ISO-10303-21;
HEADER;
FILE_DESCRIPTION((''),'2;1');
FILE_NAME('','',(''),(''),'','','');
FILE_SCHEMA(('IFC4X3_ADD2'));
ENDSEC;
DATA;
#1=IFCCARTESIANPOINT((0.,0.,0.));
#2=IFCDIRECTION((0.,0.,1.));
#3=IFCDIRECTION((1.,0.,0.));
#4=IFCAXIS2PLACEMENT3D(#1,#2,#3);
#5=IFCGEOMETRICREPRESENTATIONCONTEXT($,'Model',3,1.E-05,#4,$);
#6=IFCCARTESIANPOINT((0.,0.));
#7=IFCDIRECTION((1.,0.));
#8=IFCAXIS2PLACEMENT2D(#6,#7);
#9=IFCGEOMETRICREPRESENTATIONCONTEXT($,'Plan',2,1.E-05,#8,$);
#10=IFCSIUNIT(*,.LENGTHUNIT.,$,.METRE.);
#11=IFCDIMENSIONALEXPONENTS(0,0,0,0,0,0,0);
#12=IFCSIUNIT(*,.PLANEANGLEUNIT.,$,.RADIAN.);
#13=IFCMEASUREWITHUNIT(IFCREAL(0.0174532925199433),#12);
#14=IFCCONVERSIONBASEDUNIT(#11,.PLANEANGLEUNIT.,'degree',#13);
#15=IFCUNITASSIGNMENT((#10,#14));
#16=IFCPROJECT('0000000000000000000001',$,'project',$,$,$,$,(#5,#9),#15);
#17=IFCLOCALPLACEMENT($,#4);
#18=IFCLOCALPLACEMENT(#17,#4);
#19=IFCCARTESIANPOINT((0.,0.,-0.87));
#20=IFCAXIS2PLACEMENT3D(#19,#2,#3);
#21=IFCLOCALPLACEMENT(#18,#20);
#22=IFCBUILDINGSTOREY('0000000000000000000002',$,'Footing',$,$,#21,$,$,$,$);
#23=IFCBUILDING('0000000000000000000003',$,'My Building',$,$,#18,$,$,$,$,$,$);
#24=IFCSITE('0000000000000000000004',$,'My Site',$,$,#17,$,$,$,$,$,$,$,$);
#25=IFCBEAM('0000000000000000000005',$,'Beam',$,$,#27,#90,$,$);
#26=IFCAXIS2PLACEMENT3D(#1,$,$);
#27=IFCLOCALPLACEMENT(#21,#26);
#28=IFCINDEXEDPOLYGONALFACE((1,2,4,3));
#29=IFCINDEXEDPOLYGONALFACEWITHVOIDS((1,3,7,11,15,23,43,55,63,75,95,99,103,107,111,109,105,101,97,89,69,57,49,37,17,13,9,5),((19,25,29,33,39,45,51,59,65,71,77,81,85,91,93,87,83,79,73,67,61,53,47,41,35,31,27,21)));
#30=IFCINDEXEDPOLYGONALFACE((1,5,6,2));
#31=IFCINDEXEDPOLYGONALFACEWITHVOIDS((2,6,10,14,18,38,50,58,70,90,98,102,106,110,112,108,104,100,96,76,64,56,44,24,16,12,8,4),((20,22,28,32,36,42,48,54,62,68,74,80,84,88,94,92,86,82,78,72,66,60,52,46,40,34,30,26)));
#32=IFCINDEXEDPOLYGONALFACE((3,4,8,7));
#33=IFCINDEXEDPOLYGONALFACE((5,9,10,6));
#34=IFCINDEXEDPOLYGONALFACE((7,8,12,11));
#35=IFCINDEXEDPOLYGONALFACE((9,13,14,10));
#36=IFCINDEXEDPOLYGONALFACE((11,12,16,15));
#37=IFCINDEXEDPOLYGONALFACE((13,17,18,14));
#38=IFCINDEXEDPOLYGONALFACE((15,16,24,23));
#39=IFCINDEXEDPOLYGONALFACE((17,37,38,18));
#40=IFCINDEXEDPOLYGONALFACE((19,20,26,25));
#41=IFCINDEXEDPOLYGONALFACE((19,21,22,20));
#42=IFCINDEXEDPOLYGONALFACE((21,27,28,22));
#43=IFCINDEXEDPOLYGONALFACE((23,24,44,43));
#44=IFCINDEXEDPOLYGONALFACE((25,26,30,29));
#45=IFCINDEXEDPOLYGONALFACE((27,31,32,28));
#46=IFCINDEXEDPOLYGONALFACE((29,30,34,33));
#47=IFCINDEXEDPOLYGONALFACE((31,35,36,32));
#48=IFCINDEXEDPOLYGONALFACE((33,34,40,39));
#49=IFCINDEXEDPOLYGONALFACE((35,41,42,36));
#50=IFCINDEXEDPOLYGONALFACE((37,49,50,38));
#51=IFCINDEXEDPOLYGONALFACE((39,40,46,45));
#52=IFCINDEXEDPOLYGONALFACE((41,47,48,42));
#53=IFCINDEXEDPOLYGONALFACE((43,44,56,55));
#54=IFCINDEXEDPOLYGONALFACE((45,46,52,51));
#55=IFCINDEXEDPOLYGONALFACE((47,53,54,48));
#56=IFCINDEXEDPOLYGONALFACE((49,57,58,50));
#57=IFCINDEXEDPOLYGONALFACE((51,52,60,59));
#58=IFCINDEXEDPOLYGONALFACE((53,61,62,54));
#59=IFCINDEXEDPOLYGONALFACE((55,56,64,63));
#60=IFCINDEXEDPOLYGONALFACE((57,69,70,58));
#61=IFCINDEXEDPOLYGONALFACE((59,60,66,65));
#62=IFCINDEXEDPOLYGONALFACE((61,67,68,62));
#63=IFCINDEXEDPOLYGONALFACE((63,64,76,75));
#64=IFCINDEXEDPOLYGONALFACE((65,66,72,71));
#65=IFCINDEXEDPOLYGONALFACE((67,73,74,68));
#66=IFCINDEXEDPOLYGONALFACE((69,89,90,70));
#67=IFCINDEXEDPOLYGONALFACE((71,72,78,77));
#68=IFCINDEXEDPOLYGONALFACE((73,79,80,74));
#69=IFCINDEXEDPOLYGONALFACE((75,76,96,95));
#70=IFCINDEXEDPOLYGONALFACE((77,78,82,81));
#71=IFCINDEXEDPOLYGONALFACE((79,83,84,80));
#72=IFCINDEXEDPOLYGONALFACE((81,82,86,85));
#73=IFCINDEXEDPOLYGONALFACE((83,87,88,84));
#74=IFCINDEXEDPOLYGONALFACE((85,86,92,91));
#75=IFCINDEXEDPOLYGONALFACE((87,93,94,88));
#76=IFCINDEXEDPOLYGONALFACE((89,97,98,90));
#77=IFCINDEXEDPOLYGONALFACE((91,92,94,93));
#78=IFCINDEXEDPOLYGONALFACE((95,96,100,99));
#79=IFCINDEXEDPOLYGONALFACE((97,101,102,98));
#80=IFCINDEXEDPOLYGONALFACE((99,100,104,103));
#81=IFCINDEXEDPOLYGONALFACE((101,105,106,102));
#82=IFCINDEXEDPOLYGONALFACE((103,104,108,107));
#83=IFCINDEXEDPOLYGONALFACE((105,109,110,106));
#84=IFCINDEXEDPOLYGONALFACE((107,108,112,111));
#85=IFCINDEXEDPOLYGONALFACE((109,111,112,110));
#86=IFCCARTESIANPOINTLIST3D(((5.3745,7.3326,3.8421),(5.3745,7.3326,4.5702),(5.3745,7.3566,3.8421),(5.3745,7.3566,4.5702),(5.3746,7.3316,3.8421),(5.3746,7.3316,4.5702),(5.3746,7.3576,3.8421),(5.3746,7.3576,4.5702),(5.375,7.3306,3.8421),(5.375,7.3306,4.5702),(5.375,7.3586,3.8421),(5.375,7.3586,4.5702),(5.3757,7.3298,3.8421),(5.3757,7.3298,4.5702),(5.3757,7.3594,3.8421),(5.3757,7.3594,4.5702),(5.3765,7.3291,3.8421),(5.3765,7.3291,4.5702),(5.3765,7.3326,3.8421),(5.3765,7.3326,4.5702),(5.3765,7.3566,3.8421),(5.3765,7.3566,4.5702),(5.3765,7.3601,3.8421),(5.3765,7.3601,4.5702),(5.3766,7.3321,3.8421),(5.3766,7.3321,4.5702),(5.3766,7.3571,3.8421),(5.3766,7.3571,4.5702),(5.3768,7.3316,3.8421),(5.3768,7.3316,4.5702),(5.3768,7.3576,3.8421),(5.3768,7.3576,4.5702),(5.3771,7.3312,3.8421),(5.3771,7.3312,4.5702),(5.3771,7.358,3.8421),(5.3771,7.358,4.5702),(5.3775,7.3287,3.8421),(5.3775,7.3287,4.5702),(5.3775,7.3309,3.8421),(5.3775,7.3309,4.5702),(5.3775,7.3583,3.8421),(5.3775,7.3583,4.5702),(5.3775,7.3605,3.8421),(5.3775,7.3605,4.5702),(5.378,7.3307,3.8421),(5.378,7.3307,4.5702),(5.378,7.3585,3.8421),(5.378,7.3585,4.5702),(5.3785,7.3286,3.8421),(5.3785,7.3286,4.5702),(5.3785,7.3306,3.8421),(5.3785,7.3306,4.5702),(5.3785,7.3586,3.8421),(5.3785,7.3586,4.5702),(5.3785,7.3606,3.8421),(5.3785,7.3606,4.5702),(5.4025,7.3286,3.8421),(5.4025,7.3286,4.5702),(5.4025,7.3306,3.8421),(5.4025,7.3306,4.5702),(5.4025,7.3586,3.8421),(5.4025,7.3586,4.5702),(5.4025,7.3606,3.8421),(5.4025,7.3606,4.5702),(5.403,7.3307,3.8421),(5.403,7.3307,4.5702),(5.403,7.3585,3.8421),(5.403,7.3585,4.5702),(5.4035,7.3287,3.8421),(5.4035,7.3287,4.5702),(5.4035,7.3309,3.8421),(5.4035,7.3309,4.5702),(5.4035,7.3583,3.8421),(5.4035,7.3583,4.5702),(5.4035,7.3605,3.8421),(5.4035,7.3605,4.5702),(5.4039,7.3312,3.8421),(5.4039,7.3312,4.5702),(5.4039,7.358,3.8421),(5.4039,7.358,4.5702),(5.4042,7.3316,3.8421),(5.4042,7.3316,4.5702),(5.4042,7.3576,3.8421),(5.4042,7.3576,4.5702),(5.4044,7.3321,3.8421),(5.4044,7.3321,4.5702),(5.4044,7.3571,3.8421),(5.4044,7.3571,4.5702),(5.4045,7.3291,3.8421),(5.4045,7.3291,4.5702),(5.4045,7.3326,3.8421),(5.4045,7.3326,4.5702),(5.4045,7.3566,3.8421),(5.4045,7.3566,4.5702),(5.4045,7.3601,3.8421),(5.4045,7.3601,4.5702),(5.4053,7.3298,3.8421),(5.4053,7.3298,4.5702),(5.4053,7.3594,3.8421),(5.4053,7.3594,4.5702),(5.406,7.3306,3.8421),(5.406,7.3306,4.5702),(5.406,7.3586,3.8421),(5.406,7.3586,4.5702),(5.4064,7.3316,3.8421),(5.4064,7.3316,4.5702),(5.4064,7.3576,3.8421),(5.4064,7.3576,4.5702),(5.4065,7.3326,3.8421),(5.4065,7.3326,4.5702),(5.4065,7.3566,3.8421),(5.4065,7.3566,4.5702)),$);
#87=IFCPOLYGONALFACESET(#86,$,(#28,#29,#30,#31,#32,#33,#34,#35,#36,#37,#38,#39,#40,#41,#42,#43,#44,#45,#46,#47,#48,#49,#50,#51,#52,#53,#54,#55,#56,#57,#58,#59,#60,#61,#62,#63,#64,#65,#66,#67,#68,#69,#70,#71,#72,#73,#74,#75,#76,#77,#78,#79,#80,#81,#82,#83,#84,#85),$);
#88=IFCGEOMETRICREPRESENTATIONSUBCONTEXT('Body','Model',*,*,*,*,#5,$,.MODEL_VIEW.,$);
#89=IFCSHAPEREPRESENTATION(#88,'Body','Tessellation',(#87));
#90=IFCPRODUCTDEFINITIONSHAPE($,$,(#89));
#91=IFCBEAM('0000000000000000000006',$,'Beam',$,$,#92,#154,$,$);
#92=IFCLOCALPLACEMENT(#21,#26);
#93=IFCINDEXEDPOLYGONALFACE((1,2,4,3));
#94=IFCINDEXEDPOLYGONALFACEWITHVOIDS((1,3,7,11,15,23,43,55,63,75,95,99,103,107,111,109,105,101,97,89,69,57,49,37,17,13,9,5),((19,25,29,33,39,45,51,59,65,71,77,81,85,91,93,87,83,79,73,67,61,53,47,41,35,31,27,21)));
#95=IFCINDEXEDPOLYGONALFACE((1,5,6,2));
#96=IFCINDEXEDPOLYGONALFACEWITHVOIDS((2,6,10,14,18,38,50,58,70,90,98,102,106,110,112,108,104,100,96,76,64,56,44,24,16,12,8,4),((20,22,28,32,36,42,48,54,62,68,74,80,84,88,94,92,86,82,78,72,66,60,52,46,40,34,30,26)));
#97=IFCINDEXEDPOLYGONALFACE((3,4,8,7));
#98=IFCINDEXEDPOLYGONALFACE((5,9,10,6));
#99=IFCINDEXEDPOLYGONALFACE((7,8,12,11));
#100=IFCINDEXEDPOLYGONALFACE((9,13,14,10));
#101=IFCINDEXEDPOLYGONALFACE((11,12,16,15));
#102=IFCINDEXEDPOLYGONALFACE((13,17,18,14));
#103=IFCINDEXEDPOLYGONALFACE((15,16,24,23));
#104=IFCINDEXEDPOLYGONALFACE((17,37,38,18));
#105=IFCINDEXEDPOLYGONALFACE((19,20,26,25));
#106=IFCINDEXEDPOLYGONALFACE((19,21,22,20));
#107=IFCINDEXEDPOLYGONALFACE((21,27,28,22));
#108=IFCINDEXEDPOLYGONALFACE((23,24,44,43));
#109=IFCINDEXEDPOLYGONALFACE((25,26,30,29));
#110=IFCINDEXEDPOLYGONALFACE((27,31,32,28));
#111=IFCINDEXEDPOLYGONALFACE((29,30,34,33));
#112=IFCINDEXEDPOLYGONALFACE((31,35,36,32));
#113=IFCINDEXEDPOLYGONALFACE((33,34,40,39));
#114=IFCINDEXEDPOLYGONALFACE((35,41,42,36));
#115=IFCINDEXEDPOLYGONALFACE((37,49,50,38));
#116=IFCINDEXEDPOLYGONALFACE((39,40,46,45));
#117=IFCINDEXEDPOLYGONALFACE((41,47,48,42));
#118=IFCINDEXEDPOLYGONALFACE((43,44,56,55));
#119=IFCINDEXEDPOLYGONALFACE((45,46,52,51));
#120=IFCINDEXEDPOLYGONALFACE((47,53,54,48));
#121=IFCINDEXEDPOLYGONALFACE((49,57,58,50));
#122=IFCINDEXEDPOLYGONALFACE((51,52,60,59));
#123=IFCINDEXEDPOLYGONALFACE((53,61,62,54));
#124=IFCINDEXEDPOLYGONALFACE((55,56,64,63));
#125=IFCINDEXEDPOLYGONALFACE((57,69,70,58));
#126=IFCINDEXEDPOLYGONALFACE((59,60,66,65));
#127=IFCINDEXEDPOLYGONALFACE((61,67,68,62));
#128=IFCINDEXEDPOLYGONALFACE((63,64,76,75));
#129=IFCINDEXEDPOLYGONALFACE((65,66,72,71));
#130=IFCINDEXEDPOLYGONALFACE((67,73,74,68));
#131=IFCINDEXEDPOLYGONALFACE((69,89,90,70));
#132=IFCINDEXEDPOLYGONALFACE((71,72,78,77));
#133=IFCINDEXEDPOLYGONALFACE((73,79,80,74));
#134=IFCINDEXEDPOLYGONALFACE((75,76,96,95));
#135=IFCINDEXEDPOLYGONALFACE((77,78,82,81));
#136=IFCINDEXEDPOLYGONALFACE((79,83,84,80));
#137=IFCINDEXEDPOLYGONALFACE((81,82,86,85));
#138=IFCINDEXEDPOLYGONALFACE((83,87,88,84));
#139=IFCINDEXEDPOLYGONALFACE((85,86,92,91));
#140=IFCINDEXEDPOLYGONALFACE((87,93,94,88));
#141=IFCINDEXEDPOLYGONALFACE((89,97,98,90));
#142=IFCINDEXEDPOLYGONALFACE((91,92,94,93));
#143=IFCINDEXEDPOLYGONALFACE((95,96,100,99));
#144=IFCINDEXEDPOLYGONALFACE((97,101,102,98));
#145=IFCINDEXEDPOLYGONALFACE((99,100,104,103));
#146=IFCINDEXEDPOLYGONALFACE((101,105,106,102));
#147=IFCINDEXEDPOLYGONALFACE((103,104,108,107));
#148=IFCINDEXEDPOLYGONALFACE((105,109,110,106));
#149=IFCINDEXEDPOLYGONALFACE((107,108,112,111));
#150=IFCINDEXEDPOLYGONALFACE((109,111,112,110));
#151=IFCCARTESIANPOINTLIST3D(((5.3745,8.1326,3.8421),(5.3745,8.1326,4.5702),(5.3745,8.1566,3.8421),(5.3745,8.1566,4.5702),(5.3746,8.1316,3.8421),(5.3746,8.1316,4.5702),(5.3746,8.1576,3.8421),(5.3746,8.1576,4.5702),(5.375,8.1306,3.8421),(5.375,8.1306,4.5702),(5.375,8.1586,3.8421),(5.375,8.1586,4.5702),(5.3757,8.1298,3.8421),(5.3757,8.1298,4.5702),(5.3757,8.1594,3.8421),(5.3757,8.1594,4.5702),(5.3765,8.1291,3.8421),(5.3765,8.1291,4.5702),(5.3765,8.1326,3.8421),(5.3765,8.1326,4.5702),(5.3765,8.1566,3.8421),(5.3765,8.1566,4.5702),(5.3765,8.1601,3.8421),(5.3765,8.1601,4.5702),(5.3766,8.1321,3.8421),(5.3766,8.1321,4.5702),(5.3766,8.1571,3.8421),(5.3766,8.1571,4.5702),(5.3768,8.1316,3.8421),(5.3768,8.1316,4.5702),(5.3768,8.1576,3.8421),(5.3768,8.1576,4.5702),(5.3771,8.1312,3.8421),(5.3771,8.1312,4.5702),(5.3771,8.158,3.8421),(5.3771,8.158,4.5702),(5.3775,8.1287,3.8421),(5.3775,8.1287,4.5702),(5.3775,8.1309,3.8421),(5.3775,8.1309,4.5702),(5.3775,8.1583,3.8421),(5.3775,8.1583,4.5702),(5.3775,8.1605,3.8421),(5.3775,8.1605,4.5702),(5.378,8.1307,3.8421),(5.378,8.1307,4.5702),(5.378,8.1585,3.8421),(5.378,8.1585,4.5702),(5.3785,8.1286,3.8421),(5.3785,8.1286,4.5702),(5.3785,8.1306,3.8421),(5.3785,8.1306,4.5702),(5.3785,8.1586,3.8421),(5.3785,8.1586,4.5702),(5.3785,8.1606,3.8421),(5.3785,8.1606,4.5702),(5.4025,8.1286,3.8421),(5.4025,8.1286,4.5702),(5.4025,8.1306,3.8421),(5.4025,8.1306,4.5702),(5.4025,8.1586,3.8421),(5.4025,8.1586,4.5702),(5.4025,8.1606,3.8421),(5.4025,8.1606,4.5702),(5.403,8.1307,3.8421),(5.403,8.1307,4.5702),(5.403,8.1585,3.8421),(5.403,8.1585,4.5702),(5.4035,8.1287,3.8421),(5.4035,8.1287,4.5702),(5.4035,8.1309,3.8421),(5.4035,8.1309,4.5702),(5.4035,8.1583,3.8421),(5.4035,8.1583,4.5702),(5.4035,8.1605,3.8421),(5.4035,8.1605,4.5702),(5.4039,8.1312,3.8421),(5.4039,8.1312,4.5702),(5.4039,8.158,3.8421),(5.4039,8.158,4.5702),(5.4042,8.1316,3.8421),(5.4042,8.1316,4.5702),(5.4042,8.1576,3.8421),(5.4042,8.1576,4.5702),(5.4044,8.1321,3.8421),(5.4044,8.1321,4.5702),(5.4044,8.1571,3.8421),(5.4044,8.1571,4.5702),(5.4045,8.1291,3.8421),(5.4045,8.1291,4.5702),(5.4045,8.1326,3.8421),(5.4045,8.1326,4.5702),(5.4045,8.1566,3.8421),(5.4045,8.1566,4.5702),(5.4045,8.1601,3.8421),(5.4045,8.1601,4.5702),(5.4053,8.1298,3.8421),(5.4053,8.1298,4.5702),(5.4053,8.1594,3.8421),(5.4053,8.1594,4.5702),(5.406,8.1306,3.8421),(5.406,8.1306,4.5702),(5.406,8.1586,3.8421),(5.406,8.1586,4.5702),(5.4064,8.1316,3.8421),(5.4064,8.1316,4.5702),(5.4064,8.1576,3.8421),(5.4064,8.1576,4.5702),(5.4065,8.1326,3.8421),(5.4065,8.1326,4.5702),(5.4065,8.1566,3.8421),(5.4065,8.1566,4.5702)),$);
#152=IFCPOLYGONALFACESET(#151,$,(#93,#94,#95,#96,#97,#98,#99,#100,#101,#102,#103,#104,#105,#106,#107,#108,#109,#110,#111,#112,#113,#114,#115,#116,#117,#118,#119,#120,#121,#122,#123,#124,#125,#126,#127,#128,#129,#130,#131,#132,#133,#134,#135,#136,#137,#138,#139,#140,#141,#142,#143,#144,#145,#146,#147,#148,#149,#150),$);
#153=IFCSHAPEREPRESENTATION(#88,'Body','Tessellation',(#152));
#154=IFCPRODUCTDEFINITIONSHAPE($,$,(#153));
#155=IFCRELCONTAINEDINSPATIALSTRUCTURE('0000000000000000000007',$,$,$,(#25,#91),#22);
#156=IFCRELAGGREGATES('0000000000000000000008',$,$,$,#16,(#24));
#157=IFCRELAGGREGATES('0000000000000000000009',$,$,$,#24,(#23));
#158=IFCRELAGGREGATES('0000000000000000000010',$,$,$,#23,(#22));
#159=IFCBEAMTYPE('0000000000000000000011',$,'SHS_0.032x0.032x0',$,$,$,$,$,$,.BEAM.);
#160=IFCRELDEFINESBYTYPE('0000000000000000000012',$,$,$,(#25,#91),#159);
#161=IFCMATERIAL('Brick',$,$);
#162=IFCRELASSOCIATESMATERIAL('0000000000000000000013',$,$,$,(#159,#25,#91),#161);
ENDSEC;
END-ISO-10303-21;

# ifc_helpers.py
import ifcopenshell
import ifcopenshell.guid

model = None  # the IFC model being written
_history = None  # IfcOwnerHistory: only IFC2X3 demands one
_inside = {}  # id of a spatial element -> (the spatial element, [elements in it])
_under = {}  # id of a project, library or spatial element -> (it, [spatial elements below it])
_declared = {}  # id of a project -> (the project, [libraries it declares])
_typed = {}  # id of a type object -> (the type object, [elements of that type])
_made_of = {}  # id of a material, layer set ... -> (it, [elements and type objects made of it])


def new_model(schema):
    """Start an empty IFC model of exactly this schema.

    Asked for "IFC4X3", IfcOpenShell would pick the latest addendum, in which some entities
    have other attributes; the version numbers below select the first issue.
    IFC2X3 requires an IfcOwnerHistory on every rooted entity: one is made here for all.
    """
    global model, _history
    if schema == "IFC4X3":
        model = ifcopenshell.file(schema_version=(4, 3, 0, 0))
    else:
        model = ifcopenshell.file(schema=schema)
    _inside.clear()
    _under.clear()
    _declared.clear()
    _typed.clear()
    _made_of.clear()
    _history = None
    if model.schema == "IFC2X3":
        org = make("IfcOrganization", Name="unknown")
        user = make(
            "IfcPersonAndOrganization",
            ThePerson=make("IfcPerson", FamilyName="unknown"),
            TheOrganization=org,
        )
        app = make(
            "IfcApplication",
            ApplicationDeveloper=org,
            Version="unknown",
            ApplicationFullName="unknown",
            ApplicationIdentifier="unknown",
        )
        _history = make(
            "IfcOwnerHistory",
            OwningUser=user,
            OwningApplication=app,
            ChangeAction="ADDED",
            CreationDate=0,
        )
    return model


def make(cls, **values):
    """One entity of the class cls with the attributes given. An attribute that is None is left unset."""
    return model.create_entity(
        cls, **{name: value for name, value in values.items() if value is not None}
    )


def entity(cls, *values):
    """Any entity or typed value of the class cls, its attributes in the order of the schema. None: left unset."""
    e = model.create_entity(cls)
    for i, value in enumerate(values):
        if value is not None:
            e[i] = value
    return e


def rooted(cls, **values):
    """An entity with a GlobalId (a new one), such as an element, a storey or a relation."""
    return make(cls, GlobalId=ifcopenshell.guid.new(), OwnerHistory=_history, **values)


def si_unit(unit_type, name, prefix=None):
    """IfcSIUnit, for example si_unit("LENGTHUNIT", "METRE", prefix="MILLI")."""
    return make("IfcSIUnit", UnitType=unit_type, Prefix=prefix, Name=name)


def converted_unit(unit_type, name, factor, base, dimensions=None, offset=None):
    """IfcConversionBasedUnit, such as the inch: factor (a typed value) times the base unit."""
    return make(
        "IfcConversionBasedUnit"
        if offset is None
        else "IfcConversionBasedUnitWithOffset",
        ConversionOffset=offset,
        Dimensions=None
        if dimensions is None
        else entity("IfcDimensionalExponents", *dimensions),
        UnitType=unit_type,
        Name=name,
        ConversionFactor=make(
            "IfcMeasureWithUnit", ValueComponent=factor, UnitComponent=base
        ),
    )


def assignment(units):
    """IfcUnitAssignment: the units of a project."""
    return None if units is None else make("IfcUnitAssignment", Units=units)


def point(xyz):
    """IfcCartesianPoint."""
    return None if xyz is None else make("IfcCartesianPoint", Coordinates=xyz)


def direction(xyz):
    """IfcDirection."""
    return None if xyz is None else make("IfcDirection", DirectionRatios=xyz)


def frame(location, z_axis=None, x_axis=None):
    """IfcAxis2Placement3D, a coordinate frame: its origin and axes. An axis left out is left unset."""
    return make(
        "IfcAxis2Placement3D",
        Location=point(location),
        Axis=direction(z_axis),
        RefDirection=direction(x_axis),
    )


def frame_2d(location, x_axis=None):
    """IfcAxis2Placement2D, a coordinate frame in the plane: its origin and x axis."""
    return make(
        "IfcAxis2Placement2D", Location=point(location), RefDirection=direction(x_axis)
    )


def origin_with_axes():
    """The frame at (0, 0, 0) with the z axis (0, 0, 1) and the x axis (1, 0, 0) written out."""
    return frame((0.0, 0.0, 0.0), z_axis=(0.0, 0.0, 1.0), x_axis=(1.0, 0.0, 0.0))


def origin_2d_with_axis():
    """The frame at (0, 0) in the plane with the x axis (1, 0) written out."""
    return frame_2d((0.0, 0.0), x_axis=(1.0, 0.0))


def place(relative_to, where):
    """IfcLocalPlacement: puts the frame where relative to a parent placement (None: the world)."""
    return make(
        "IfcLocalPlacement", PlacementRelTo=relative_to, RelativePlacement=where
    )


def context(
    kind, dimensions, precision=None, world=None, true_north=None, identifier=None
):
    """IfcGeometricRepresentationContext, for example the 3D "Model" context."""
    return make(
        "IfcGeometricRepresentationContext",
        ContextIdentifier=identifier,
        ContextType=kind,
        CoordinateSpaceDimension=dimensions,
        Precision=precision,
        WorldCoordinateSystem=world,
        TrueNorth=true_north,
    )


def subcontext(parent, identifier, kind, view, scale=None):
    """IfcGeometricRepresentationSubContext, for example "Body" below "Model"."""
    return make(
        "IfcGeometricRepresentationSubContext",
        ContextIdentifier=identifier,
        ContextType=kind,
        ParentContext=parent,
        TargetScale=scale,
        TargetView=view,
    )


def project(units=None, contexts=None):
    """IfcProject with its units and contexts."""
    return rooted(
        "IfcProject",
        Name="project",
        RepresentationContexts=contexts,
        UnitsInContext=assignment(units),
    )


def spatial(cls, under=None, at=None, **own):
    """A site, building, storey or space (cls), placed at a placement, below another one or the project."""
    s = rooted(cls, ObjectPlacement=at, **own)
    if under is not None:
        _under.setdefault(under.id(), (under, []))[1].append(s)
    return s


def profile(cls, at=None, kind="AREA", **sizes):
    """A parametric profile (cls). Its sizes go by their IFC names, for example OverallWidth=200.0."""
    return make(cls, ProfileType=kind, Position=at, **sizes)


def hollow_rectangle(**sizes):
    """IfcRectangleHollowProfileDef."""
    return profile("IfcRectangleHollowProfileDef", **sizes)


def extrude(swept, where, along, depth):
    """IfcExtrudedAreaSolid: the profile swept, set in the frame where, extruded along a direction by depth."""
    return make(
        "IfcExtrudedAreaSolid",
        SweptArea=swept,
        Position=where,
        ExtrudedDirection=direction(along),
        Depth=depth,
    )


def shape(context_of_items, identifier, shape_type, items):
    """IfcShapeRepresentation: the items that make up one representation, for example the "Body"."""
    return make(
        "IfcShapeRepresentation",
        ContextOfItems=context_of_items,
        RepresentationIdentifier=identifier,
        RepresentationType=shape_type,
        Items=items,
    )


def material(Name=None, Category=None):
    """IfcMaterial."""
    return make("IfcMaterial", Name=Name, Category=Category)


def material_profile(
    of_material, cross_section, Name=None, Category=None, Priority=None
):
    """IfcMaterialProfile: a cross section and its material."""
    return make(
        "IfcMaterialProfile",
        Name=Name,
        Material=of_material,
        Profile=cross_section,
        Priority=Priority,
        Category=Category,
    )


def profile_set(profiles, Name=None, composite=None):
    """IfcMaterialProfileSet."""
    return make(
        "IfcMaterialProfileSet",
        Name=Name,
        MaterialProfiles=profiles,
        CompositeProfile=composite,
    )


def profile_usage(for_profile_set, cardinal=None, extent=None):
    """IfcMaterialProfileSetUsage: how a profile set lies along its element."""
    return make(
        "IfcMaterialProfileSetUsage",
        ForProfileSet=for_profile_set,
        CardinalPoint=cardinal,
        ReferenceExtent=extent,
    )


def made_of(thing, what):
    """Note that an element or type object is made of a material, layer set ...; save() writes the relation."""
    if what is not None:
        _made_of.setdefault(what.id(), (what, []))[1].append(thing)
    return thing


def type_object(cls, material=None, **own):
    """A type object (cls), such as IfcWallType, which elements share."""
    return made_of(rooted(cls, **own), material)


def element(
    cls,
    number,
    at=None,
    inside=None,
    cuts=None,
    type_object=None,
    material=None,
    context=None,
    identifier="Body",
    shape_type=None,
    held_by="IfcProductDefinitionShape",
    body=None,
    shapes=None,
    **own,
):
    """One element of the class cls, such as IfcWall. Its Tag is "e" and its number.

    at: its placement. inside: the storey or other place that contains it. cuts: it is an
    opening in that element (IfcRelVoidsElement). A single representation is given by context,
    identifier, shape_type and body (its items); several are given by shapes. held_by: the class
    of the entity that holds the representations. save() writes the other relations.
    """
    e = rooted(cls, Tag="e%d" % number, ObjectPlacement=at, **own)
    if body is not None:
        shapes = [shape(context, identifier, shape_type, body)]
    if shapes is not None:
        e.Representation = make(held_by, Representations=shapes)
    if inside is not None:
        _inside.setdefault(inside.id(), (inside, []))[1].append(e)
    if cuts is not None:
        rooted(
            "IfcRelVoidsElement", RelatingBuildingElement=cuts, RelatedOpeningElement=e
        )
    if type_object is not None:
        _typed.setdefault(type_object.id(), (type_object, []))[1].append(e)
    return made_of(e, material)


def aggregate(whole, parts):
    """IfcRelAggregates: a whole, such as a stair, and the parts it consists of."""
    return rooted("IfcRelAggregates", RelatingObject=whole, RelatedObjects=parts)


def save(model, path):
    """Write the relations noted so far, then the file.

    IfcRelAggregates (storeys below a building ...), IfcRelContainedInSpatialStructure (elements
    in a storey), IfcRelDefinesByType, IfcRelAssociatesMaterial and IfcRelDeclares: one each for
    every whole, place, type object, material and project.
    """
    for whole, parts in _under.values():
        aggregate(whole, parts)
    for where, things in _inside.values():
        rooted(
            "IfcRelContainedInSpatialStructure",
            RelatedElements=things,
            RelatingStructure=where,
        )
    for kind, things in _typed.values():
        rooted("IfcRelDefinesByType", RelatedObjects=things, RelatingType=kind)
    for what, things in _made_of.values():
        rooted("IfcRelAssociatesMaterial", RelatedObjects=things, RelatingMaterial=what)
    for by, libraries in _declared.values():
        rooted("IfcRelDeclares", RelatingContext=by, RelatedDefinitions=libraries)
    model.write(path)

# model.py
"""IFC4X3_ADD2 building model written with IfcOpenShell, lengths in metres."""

from ifc_helpers import new_model, entity, si_unit, converted_unit, frame, origin_with_axes, origin_2d_with_axis, place, context, subcontext, project, spatial, hollow_rectangle, extrude, material, material_profile, profile_set, profile_usage, type_object, element, save


model = new_model("IFC4X3_ADD2")

# Units and contexts
model_context = context("Model", 3, precision=1e-05, world=origin_with_axes())
plan_context = context("Plan", 2, precision=1e-05, world=origin_2d_with_axis())
body_context = subcontext(model_context, "Body", "Model", "MODEL_VIEW")
ifc_project = project(units=[si_unit("LENGTHUNIT", "METRE"), converted_unit("PLANEANGLEUNIT", "degree", entity("IfcReal", 0.0174532925199433), si_unit("PLANEANGLEUNIT", "RADIAN"), dimensions=[0, 0, 0, 0, 0, 0, 0])], contexts=[model_context, plan_context])

# Site, building, storey
site_placement = place(None, origin_with_axes())
site = spatial("IfcSite", under=ifc_project, at=site_placement, Name="My Site")
building_placement = place(site_placement, origin_with_axes())
building = spatial("IfcBuilding", under=site, at=building_placement, Name="My Building")
storey_placement = place(building_placement, frame((0.0, 0.0, -0.87), z_axis=(0.0, 0.0, 1.0), x_axis=(1.0, 0.0, 0.0)))
storey = spatial("IfcBuildingStorey", under=building, at=storey_placement, Name="Footing")

# Beams
ifc_material_1 = material(Name="Brick")
ifc_material_profile = material_profile(ifc_material_1, hollow_rectangle(XDim=0.032, YDim=0.032, WallThickness=0.002, InnerFilletRadius=0.002, OuterFilletRadius=0.004))
ifc_profile_set = profile_set([ifc_material_profile])
beam_type_1 = type_object("IfcBeamType", Name="SHS_0.032x0.032x0", PredefinedType="BEAM", material=ifc_profile_set)
ifc_profile_usage_1 = profile_usage(ifc_profile_set, cardinal=5)
beam_1_placement = place(storey_placement, frame((5.3905, 7.3446, 3.8421), z_axis=(0.0, 0.0, 1.0), x_axis=(1.0, 0.0, 0.0)))
element("IfcBeam", 1, at=beam_1_placement, inside=storey, type_object=beam_type_1, material=ifc_profile_usage_1, Name="Beam", context=body_context, shape_type="SweptSolid", body=[
    extrude(hollow_rectangle(XDim=0.032, YDim=0.032, WallThickness=0.002, InnerFilletRadius=0.002, OuterFilletRadius=0.004), origin_with_axes(), (0.0, 0.0, 1.0), 0.7281),
])
ifc_profile_usage_2 = profile_usage(ifc_profile_set, cardinal=5)
beam_2_placement = place(storey_placement, frame((5.3905, 8.1446, 3.8421), z_axis=(0.0, 0.0, 1.0), x_axis=(1.0, 0.0, 0.0)))
element("IfcBeam", 2, at=beam_2_placement, inside=storey, type_object=beam_type_1, material=ifc_profile_usage_2, Name="Beam", context=body_context, shape_type="SweptSolid", body=[
    extrude(hollow_rectangle(XDim=0.032, YDim=0.032, WallThickness=0.002, InnerFilletRadius=0.002, OuterFilletRadius=0.004), origin_with_axes(), (0.0, 0.0, 1.0), 0.7281),
])

save(model, "model.ifc")
